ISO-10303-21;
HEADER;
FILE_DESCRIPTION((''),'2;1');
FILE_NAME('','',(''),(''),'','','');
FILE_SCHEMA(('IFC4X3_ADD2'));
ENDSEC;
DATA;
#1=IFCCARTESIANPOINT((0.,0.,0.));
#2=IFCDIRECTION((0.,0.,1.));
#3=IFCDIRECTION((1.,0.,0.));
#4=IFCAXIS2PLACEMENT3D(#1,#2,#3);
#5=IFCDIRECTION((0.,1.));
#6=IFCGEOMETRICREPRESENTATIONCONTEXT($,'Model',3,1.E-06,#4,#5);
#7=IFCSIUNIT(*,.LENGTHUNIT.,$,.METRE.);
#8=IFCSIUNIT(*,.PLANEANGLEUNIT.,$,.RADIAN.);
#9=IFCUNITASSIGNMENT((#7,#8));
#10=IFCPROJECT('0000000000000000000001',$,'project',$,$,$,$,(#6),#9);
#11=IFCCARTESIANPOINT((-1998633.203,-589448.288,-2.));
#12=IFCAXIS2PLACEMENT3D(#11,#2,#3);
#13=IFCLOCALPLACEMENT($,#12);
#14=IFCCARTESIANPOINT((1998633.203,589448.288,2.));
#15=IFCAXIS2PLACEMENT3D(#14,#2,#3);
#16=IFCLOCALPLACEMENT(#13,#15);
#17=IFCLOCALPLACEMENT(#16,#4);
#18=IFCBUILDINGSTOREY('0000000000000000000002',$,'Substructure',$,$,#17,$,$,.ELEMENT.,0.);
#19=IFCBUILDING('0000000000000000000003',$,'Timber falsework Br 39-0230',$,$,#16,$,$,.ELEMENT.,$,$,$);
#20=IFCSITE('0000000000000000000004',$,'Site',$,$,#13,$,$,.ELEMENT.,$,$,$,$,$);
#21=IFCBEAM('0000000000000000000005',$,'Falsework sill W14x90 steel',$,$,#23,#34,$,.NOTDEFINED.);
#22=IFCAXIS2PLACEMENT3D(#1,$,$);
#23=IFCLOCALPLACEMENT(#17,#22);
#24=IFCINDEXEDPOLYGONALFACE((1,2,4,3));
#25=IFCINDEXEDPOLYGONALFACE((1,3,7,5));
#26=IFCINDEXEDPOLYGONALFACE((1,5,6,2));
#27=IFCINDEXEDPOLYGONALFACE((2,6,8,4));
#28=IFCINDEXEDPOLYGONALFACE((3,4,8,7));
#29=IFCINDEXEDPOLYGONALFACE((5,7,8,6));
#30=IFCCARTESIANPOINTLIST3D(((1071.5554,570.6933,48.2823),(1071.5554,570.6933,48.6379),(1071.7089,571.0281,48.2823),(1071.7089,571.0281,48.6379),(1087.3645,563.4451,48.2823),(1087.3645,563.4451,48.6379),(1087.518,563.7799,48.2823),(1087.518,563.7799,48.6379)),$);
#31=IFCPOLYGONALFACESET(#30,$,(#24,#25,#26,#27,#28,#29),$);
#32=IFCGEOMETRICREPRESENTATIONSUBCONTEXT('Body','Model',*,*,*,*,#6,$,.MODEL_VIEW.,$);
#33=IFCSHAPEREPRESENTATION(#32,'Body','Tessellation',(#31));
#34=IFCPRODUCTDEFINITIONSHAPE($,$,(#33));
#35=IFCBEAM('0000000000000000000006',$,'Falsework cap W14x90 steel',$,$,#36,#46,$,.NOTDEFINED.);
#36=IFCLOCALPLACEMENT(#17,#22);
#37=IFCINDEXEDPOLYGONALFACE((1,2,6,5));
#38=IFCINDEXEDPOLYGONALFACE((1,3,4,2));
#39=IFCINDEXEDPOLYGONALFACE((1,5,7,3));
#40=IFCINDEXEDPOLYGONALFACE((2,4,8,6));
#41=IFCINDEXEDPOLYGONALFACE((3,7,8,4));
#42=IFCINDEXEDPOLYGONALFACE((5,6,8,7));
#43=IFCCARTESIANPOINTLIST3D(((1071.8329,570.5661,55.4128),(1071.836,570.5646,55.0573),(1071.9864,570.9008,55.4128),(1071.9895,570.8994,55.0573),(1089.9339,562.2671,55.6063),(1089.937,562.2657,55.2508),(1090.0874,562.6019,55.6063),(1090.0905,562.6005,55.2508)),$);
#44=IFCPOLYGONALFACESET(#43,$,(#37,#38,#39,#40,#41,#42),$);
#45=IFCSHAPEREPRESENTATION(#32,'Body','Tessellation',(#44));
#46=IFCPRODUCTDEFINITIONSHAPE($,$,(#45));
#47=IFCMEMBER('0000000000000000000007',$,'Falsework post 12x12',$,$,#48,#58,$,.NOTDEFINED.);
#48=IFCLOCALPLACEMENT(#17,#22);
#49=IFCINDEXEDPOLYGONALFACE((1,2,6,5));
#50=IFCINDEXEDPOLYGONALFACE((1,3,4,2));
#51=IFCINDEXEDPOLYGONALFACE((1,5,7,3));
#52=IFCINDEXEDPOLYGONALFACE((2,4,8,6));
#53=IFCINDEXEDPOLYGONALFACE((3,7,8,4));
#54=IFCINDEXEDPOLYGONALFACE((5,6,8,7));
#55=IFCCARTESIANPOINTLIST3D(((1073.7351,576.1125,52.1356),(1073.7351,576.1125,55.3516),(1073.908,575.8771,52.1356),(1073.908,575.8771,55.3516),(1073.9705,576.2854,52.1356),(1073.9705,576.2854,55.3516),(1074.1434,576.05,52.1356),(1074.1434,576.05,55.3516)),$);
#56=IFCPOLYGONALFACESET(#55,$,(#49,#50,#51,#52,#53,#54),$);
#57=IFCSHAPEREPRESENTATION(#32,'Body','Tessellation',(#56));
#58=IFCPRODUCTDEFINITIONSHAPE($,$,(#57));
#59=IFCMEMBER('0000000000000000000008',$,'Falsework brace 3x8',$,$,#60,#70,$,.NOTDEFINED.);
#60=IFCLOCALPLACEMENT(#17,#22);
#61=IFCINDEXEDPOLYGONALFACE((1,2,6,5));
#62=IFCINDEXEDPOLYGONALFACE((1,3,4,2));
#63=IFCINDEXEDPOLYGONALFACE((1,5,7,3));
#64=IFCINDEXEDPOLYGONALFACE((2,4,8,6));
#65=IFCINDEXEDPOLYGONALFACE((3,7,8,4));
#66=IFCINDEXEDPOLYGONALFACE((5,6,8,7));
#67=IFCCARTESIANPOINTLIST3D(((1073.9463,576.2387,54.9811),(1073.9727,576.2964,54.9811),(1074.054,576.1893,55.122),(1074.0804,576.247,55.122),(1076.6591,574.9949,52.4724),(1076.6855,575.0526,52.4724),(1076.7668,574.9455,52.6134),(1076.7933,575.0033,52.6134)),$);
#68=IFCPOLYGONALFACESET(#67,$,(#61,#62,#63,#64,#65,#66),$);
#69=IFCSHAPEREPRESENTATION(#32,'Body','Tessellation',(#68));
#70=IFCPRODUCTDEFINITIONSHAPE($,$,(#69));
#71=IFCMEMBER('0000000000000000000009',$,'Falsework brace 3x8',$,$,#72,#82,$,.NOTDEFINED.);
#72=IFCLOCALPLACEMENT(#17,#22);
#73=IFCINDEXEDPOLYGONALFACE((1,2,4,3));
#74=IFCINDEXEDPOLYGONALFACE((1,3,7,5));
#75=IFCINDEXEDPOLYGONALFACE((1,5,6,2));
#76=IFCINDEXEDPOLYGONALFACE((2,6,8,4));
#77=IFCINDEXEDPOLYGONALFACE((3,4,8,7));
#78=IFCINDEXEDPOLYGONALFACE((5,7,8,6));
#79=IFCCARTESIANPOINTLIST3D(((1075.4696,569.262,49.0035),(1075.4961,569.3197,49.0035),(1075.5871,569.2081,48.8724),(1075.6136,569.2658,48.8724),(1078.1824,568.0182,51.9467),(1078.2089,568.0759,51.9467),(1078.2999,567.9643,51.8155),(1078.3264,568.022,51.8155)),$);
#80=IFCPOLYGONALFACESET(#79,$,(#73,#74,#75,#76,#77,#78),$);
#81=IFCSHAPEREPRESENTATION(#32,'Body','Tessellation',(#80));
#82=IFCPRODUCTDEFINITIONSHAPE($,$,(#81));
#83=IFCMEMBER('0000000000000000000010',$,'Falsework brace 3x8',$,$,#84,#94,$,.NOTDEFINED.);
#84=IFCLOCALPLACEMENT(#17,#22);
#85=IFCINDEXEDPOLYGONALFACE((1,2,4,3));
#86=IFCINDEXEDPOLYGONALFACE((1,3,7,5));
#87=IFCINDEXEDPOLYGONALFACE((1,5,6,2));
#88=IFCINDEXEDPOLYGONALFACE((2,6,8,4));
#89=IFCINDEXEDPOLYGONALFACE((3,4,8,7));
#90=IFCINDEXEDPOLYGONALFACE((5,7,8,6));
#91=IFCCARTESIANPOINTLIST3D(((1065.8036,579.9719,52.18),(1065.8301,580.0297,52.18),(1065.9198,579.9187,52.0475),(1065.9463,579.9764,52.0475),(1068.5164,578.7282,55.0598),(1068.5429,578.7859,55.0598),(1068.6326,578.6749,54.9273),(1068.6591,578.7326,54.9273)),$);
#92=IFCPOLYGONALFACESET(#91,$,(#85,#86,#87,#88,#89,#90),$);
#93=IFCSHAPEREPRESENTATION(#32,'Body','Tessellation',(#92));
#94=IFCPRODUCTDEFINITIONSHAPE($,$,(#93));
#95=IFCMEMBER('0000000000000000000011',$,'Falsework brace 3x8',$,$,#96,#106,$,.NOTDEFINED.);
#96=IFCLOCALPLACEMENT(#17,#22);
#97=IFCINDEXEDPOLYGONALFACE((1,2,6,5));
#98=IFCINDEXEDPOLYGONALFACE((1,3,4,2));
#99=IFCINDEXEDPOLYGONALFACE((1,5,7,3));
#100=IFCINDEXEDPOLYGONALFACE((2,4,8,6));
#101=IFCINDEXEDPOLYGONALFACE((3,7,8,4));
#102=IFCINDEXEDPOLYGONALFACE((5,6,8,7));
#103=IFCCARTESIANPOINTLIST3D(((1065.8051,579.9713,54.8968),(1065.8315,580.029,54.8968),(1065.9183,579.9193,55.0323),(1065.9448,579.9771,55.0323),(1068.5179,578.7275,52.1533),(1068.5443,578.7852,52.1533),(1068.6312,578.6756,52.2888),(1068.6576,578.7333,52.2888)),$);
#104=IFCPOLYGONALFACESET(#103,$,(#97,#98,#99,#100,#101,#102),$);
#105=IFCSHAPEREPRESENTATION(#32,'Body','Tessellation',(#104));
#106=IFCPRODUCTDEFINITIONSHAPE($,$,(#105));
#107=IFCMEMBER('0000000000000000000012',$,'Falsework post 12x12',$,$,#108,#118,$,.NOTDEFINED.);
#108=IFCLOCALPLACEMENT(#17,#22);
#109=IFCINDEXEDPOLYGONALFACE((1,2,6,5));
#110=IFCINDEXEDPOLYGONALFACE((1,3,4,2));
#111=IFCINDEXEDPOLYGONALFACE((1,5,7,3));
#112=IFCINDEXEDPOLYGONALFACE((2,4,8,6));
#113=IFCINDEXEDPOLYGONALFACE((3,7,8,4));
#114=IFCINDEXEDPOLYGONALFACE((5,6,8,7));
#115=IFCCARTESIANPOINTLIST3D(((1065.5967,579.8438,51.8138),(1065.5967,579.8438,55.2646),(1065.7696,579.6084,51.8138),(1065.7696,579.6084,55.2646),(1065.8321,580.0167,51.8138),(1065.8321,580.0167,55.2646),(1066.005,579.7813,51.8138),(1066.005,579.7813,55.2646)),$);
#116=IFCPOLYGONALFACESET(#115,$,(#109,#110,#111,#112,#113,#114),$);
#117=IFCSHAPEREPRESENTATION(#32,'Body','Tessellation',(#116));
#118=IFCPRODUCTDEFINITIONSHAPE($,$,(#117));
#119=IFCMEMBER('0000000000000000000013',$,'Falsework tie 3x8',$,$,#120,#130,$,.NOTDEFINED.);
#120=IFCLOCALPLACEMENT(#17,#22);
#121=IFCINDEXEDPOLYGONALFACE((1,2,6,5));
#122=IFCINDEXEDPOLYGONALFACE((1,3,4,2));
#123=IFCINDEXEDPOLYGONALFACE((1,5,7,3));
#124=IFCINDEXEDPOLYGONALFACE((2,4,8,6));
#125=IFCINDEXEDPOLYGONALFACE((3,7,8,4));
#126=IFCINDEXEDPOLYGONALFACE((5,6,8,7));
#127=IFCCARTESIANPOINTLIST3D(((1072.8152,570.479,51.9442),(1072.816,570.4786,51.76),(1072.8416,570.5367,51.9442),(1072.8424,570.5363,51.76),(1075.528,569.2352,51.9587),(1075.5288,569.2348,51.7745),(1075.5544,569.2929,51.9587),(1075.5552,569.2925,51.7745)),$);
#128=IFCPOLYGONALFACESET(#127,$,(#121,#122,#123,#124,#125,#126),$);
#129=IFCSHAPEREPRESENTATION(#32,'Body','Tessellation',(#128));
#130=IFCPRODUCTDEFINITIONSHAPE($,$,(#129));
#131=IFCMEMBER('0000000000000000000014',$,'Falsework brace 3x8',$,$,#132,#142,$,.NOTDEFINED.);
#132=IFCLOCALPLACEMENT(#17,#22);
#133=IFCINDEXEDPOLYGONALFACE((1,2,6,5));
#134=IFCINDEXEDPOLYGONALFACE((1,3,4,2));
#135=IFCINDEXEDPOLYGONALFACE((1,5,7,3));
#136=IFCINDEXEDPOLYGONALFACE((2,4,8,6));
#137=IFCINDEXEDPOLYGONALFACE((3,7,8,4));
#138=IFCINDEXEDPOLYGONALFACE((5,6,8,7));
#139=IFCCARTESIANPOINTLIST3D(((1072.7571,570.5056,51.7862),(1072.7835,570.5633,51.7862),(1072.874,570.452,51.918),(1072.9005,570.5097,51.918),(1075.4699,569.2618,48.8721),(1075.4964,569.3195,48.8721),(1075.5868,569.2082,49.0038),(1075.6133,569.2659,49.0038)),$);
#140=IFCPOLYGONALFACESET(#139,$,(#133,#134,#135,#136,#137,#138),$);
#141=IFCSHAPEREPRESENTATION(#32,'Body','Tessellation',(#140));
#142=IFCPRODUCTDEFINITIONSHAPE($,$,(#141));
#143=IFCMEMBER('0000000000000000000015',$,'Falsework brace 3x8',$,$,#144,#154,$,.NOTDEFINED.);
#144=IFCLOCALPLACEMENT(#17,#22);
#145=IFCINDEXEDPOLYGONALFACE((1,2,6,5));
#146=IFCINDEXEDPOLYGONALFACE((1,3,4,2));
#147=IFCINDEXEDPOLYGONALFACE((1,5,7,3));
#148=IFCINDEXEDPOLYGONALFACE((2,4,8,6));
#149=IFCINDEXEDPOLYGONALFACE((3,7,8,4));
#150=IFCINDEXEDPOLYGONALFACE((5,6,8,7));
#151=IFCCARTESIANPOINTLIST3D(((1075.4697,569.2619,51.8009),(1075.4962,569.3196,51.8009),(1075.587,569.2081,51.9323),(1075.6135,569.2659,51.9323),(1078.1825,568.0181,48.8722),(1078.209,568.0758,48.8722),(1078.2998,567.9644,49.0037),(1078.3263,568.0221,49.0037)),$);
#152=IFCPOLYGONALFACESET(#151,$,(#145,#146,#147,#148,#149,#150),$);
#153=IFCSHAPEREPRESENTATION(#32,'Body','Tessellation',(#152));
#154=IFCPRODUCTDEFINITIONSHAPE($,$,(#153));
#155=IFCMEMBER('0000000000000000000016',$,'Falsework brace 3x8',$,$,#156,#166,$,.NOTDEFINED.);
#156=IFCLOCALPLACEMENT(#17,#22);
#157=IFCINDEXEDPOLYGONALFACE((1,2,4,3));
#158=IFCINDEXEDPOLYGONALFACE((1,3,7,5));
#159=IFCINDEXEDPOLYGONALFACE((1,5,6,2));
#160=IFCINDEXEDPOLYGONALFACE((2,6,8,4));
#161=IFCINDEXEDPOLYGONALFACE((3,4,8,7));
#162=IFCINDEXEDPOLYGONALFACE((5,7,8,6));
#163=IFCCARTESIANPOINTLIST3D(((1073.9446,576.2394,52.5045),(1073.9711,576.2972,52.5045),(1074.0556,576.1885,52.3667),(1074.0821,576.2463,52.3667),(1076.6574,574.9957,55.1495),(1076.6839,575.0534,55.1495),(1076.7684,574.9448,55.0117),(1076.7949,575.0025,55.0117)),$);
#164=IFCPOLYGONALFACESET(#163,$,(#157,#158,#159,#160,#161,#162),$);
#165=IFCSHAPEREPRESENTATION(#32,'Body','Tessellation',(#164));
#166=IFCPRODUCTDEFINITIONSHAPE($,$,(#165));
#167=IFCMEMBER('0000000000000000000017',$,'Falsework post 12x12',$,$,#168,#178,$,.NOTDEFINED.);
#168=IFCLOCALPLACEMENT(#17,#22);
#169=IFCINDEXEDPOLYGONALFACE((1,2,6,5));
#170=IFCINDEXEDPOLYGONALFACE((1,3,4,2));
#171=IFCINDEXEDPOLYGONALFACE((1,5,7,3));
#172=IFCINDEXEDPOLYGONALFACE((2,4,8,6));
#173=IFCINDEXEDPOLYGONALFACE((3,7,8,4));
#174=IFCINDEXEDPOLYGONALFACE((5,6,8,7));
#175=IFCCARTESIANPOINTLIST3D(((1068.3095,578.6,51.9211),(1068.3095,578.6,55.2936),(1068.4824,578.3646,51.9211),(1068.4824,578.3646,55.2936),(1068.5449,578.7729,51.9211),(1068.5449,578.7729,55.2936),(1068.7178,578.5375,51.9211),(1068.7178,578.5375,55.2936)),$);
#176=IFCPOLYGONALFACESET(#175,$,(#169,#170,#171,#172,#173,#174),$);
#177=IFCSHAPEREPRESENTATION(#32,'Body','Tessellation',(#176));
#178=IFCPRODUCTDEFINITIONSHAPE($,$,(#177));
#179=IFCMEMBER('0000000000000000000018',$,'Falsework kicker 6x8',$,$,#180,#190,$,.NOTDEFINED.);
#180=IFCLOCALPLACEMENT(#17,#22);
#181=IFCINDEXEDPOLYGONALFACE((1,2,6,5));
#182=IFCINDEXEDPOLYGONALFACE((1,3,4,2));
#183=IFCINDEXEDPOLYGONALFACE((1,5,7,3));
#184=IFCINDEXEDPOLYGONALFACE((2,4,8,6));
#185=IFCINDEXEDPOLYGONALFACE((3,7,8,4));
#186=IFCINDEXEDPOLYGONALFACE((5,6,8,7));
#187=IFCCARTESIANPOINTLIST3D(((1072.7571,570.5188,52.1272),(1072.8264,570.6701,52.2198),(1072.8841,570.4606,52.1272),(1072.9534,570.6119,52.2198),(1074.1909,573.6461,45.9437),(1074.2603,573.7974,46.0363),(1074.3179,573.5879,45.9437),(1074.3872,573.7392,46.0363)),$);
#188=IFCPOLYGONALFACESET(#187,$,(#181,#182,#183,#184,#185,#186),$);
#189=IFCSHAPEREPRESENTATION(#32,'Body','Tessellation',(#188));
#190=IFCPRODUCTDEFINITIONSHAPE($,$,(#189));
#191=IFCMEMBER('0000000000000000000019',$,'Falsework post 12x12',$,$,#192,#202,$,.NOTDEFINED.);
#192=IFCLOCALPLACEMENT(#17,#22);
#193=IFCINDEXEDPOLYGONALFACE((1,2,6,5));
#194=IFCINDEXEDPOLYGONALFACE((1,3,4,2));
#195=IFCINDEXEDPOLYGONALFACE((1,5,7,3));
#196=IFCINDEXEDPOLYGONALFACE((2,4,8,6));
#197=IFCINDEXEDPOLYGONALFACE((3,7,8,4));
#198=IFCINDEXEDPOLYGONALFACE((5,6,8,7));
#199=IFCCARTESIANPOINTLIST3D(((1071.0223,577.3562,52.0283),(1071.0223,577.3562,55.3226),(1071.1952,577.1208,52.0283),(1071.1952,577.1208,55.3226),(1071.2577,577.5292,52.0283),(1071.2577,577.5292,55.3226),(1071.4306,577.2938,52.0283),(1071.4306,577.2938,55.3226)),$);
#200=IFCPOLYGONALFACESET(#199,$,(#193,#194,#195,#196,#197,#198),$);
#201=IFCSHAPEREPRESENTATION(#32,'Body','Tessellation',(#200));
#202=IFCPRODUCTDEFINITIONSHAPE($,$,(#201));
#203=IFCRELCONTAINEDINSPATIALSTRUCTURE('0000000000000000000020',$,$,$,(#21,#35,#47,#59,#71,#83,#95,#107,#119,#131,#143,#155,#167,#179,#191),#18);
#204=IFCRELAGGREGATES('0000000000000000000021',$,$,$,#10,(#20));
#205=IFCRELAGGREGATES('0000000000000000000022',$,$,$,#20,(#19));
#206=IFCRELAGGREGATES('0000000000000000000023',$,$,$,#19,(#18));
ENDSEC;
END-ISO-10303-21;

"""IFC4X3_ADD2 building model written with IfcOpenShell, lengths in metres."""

from ifc_helpers import new_model, si_unit, direction, frame, frame_2d, origin, origin_with_axes, origin_2d, place, context, subcontext, project, spatial, rectangle, extrude, element, save


model = new_model("IFC4X3_ADD2")

# Units and contexts
model_context = context("Model", 3, precision=1e-06, world=origin_with_axes(), true_north=direction((0.0, 1.0)))
body_context = subcontext(model_context, "Body", "Model", "MODEL_VIEW")
ifc_project = project(units=[si_unit("LENGTHUNIT", "METRE"), si_unit("PLANEANGLEUNIT", "RADIAN")], contexts=[model_context])

# Site, building, storey
site_placement = place(None, frame((-1998633.203, -589448.288, -2.0), z_axis=(0.0, 0.0, 1.0), x_axis=(1.0, 0.0, 0.0)))
site = spatial("IfcSite", under=ifc_project, at=site_placement, Name="Site", CompositionType="ELEMENT")
building_placement = place(site_placement, frame((1998633.203, 589448.288, 2.0), z_axis=(0.0, 0.0, 1.0), x_axis=(1.0, 0.0, 0.0)))
building = spatial("IfcBuilding", under=site, at=building_placement, Name="Timber falsework Br 39-0230", CompositionType="ELEMENT")
storey_placement = place(building_placement, origin_with_axes())
storey = spatial("IfcBuildingStorey", under=building, at=storey_placement, Name="Substructure", CompositionType="ELEMENT", Elevation=0.0)

# Beams
beam_1_placement = place(storey_placement, frame((1071.6321, 570.8607, 48.2823), z_axis=(0.909014, -0.416765, 0.0), x_axis=(0.416765, 0.909014, 0.0)))
element("IfcBeam", 1, at=beam_1_placement, inside=storey, Name="Falsework sill W14x90 steel", PredefinedType="NOTDEFINED", context=body_context, shape_type="SweptSolid", body=[
    extrude(rectangle(XDim=0.3683, YDim=0.3556, at=frame_2d((0.0, 0.1778))), origin(), (0.0, 0.0, 1.0), 17.3915),
])
beam_2_placement = place(storey_placement, frame((1071.9128, 570.732, 55.0573), z_axis=(0.908971, -0.416746, 0.009717), x_axis=(0.416765, 0.909014, 0.0)))
element("IfcBeam", 2, at=beam_2_placement, inside=storey, Name="Falsework cap W14x90 steel", PredefinedType="NOTDEFINED", context=body_context, shape_type="SweptSolid", body=[
    extrude(rectangle(XDim=0.3683, YDim=0.3556, at=frame_2d((0.0, 0.1778))), origin(), (0.0, 0.0, 1.0), 19.9137),
])

# Members
member_1_placement = place(storey_placement, frame((1073.9393, 576.0812, 52.1356), z_axis=(0.0, 0.0, 1.0), x_axis=(-0.805928, -0.592013, 0.0)))
element("IfcMember", 3, at=member_1_placement, inside=storey, Name="Falsework post 12x12", PredefinedType="NOTDEFINED", context=body_context, shape_type="SweptSolid", body=[
    extrude(rectangle(XDim=0.2921, YDim=0.2921, at=origin_2d()), origin(), (0.0, 0.0, 1.0), 3.2159),
])
member_2_placement = place(storey_placement, frame((1074.0134, 576.2429, 55.0516), z_axis=(0.695828, -0.319023, -0.643465), x_axis=(0.416765, 0.909014, 0.0)))
element("IfcMember", 4, at=member_2_placement, inside=storey, Name="Falsework brace 3x8", PredefinedType="NOTDEFINED", context=body_context, shape_type="SweptSolid", body=[
    extrude(rectangle(XDim=0.0635, YDim=0.1841, at=origin_2d()), origin(), (0.0, 0.0, 1.0), 3.8987),
])
member_3_placement = place(storey_placement, frame((1075.5416, 569.2639, 48.9379), z_axis=(0.64722, -0.296738, 0.702178), x_axis=(0.416765, 0.909014, 0.0)))
element("IfcMember", 5, at=member_3_placement, inside=storey, Name="Falsework brace 3x8", PredefinedType="NOTDEFINED", context=body_context, shape_type="SweptSolid", body=[
    extrude(rectangle(XDim=0.0635, YDim=0.1841, at=origin_2d()), origin(), (0.0, 0.0, 1.0), 4.1915),
])
member_4_placement = place(storey_placement, frame((1065.8749, 579.9742, 52.1138), z_axis=(0.654128, -0.299905, 0.694388), x_axis=(0.416765, 0.909014, 0.0)))
element("IfcMember", 6, at=member_4_placement, inside=storey, Name="Falsework brace 3x8", PredefinedType="NOTDEFINED", context=body_context, shape_type="SweptSolid", body=[
    extrude(rectangle(XDim=0.0635, YDim=0.1841, at=origin_2d()), origin(), (0.0, 0.0, 1.0), 4.1472),
])
member_5_placement = place(storey_placement, frame((1065.8749, 579.9742, 54.9646), z_axis=(0.669206, -0.306818, -0.676776), x_axis=(0.416765, 0.909014, 0.0)))
element("IfcMember", 7, at=member_5_placement, inside=storey, Name="Falsework brace 3x8", PredefinedType="NOTDEFINED", context=body_context, shape_type="SweptSolid", body=[
    extrude(rectangle(XDim=0.0635, YDim=0.1841, at=origin_2d()), origin(), (0.0, 0.0, 1.0), 4.0538),
])
member_6_placement = place(storey_placement, frame((1065.8008, 579.8125, 51.8138), z_axis=(0.0, 0.0, 1.0), x_axis=(-0.805928, -0.592013, 0.0)))
element("IfcMember", 8, at=member_6_placement, inside=storey, Name="Falsework post 12x12", PredefinedType="NOTDEFINED", context=body_context, shape_type="SweptSolid", body=[
    extrude(rectangle(XDim=0.2921, YDim=0.2921, at=origin_2d()), origin(), (0.0, 0.0, 1.0), 3.4508),
])
member_7_placement = place(storey_placement, frame((1072.8288, 570.5076, 51.8521), z_axis=(0.909003, -0.41676, 0.004859), x_axis=(0.416765, 0.909014, 0.0)))
element("IfcMember", 9, at=member_7_placement, inside=storey, Name="Falsework tie 3x8", PredefinedType="NOTDEFINED", context=body_context, shape_type="SweptSolid", body=[
    extrude(rectangle(XDim=0.0635, YDim=0.1841, at=origin_2d()), origin(), (0.0, 0.0, 1.0), 2.9844),
])
member_8_placement = place(storey_placement, frame((1072.8288, 570.5076, 51.8521), z_axis=(0.650372, -0.298183, -0.698644), x_axis=(0.416765, 0.909014, 0.0)))
element("IfcMember", 10, at=member_8_placement, inside=storey, Name="Falsework brace 3x8", PredefinedType="NOTDEFINED", context=body_context, shape_type="SweptSolid", body=[
    extrude(rectangle(XDim=0.0635, YDim=0.1841, at=origin_2d()), origin(), (0.0, 0.0, 1.0), 4.1712),
])
member_9_placement = place(storey_placement, frame((1075.5416, 569.2639, 51.8666), z_axis=(0.648794, -0.297459, -0.700417), x_axis=(0.416765, 0.909014, 0.0)))
element("IfcMember", 11, at=member_9_placement, inside=storey, Name="Falsework brace 3x8", PredefinedType="NOTDEFINED", context=body_context, shape_type="SweptSolid", body=[
    extrude(rectangle(XDim=0.0635, YDim=0.1841, at=origin_2d()), origin(), (0.0, 0.0, 1.0), 4.1813),
])
member_10_placement = place(storey_placement, frame((1074.0134, 576.2429, 52.4356), z_axis=(0.680288, -0.311899, 0.66327), x_axis=(0.416765, 0.909014, 0.0)))
element("IfcMember", 12, at=member_10_placement, inside=storey, Name="Falsework brace 3x8", PredefinedType="NOTDEFINED", context=body_context, shape_type="SweptSolid", body=[
    extrude(rectangle(XDim=0.0635, YDim=0.1841, at=origin_2d()), origin(), (0.0, 0.0, 1.0), 3.9877),
])
member_11_placement = place(storey_placement, frame((1068.5136, 578.5688, 51.9211), z_axis=(0.0, 0.0, 1.0), x_axis=(-0.805928, -0.592013, 0.0)))
element("IfcMember", 13, at=member_11_placement, inside=storey, Name="Falsework post 12x12", PredefinedType="NOTDEFINED", context=body_context, shape_type="SweptSolid", body=[
    extrude(rectangle(XDim=0.2921, YDim=0.2921, at=origin_2d()), origin(), (0.0, 0.0, 1.0), 3.3725),
])
member_12_placement = place(storey_placement, frame((1072.8553, 570.5654, 52.1735), z_axis=(0.202626, 0.441951, -0.873855), x_axis=(-0.909014, 0.416765, 0.0)))
element("IfcMember", 14, at=member_12_placement, inside=storey, Name="Falsework kicker 6x8", PredefinedType="NOTDEFINED", context=body_context, shape_type="SweptSolid", body=[
    extrude(rectangle(XDim=0.1397, YDim=0.1905, at=origin_2d()), origin(), (0.0, 0.0, 1.0), 7.0761),
])
member_13_placement = place(storey_placement, frame((1071.2264, 577.325, 52.0283), z_axis=(0.0, 0.0, 1.0), x_axis=(-0.805928, -0.592013, 0.0)))
element("IfcMember", 15, at=member_13_placement, inside=storey, Name="Falsework post 12x12", PredefinedType="NOTDEFINED", context=body_context, shape_type="SweptSolid", body=[
    extrude(rectangle(XDim=0.2921, YDim=0.2921, at=origin_2d()), origin(), (0.0, 0.0, 1.0), 3.2942),
])

save(model, "model.ifc")
